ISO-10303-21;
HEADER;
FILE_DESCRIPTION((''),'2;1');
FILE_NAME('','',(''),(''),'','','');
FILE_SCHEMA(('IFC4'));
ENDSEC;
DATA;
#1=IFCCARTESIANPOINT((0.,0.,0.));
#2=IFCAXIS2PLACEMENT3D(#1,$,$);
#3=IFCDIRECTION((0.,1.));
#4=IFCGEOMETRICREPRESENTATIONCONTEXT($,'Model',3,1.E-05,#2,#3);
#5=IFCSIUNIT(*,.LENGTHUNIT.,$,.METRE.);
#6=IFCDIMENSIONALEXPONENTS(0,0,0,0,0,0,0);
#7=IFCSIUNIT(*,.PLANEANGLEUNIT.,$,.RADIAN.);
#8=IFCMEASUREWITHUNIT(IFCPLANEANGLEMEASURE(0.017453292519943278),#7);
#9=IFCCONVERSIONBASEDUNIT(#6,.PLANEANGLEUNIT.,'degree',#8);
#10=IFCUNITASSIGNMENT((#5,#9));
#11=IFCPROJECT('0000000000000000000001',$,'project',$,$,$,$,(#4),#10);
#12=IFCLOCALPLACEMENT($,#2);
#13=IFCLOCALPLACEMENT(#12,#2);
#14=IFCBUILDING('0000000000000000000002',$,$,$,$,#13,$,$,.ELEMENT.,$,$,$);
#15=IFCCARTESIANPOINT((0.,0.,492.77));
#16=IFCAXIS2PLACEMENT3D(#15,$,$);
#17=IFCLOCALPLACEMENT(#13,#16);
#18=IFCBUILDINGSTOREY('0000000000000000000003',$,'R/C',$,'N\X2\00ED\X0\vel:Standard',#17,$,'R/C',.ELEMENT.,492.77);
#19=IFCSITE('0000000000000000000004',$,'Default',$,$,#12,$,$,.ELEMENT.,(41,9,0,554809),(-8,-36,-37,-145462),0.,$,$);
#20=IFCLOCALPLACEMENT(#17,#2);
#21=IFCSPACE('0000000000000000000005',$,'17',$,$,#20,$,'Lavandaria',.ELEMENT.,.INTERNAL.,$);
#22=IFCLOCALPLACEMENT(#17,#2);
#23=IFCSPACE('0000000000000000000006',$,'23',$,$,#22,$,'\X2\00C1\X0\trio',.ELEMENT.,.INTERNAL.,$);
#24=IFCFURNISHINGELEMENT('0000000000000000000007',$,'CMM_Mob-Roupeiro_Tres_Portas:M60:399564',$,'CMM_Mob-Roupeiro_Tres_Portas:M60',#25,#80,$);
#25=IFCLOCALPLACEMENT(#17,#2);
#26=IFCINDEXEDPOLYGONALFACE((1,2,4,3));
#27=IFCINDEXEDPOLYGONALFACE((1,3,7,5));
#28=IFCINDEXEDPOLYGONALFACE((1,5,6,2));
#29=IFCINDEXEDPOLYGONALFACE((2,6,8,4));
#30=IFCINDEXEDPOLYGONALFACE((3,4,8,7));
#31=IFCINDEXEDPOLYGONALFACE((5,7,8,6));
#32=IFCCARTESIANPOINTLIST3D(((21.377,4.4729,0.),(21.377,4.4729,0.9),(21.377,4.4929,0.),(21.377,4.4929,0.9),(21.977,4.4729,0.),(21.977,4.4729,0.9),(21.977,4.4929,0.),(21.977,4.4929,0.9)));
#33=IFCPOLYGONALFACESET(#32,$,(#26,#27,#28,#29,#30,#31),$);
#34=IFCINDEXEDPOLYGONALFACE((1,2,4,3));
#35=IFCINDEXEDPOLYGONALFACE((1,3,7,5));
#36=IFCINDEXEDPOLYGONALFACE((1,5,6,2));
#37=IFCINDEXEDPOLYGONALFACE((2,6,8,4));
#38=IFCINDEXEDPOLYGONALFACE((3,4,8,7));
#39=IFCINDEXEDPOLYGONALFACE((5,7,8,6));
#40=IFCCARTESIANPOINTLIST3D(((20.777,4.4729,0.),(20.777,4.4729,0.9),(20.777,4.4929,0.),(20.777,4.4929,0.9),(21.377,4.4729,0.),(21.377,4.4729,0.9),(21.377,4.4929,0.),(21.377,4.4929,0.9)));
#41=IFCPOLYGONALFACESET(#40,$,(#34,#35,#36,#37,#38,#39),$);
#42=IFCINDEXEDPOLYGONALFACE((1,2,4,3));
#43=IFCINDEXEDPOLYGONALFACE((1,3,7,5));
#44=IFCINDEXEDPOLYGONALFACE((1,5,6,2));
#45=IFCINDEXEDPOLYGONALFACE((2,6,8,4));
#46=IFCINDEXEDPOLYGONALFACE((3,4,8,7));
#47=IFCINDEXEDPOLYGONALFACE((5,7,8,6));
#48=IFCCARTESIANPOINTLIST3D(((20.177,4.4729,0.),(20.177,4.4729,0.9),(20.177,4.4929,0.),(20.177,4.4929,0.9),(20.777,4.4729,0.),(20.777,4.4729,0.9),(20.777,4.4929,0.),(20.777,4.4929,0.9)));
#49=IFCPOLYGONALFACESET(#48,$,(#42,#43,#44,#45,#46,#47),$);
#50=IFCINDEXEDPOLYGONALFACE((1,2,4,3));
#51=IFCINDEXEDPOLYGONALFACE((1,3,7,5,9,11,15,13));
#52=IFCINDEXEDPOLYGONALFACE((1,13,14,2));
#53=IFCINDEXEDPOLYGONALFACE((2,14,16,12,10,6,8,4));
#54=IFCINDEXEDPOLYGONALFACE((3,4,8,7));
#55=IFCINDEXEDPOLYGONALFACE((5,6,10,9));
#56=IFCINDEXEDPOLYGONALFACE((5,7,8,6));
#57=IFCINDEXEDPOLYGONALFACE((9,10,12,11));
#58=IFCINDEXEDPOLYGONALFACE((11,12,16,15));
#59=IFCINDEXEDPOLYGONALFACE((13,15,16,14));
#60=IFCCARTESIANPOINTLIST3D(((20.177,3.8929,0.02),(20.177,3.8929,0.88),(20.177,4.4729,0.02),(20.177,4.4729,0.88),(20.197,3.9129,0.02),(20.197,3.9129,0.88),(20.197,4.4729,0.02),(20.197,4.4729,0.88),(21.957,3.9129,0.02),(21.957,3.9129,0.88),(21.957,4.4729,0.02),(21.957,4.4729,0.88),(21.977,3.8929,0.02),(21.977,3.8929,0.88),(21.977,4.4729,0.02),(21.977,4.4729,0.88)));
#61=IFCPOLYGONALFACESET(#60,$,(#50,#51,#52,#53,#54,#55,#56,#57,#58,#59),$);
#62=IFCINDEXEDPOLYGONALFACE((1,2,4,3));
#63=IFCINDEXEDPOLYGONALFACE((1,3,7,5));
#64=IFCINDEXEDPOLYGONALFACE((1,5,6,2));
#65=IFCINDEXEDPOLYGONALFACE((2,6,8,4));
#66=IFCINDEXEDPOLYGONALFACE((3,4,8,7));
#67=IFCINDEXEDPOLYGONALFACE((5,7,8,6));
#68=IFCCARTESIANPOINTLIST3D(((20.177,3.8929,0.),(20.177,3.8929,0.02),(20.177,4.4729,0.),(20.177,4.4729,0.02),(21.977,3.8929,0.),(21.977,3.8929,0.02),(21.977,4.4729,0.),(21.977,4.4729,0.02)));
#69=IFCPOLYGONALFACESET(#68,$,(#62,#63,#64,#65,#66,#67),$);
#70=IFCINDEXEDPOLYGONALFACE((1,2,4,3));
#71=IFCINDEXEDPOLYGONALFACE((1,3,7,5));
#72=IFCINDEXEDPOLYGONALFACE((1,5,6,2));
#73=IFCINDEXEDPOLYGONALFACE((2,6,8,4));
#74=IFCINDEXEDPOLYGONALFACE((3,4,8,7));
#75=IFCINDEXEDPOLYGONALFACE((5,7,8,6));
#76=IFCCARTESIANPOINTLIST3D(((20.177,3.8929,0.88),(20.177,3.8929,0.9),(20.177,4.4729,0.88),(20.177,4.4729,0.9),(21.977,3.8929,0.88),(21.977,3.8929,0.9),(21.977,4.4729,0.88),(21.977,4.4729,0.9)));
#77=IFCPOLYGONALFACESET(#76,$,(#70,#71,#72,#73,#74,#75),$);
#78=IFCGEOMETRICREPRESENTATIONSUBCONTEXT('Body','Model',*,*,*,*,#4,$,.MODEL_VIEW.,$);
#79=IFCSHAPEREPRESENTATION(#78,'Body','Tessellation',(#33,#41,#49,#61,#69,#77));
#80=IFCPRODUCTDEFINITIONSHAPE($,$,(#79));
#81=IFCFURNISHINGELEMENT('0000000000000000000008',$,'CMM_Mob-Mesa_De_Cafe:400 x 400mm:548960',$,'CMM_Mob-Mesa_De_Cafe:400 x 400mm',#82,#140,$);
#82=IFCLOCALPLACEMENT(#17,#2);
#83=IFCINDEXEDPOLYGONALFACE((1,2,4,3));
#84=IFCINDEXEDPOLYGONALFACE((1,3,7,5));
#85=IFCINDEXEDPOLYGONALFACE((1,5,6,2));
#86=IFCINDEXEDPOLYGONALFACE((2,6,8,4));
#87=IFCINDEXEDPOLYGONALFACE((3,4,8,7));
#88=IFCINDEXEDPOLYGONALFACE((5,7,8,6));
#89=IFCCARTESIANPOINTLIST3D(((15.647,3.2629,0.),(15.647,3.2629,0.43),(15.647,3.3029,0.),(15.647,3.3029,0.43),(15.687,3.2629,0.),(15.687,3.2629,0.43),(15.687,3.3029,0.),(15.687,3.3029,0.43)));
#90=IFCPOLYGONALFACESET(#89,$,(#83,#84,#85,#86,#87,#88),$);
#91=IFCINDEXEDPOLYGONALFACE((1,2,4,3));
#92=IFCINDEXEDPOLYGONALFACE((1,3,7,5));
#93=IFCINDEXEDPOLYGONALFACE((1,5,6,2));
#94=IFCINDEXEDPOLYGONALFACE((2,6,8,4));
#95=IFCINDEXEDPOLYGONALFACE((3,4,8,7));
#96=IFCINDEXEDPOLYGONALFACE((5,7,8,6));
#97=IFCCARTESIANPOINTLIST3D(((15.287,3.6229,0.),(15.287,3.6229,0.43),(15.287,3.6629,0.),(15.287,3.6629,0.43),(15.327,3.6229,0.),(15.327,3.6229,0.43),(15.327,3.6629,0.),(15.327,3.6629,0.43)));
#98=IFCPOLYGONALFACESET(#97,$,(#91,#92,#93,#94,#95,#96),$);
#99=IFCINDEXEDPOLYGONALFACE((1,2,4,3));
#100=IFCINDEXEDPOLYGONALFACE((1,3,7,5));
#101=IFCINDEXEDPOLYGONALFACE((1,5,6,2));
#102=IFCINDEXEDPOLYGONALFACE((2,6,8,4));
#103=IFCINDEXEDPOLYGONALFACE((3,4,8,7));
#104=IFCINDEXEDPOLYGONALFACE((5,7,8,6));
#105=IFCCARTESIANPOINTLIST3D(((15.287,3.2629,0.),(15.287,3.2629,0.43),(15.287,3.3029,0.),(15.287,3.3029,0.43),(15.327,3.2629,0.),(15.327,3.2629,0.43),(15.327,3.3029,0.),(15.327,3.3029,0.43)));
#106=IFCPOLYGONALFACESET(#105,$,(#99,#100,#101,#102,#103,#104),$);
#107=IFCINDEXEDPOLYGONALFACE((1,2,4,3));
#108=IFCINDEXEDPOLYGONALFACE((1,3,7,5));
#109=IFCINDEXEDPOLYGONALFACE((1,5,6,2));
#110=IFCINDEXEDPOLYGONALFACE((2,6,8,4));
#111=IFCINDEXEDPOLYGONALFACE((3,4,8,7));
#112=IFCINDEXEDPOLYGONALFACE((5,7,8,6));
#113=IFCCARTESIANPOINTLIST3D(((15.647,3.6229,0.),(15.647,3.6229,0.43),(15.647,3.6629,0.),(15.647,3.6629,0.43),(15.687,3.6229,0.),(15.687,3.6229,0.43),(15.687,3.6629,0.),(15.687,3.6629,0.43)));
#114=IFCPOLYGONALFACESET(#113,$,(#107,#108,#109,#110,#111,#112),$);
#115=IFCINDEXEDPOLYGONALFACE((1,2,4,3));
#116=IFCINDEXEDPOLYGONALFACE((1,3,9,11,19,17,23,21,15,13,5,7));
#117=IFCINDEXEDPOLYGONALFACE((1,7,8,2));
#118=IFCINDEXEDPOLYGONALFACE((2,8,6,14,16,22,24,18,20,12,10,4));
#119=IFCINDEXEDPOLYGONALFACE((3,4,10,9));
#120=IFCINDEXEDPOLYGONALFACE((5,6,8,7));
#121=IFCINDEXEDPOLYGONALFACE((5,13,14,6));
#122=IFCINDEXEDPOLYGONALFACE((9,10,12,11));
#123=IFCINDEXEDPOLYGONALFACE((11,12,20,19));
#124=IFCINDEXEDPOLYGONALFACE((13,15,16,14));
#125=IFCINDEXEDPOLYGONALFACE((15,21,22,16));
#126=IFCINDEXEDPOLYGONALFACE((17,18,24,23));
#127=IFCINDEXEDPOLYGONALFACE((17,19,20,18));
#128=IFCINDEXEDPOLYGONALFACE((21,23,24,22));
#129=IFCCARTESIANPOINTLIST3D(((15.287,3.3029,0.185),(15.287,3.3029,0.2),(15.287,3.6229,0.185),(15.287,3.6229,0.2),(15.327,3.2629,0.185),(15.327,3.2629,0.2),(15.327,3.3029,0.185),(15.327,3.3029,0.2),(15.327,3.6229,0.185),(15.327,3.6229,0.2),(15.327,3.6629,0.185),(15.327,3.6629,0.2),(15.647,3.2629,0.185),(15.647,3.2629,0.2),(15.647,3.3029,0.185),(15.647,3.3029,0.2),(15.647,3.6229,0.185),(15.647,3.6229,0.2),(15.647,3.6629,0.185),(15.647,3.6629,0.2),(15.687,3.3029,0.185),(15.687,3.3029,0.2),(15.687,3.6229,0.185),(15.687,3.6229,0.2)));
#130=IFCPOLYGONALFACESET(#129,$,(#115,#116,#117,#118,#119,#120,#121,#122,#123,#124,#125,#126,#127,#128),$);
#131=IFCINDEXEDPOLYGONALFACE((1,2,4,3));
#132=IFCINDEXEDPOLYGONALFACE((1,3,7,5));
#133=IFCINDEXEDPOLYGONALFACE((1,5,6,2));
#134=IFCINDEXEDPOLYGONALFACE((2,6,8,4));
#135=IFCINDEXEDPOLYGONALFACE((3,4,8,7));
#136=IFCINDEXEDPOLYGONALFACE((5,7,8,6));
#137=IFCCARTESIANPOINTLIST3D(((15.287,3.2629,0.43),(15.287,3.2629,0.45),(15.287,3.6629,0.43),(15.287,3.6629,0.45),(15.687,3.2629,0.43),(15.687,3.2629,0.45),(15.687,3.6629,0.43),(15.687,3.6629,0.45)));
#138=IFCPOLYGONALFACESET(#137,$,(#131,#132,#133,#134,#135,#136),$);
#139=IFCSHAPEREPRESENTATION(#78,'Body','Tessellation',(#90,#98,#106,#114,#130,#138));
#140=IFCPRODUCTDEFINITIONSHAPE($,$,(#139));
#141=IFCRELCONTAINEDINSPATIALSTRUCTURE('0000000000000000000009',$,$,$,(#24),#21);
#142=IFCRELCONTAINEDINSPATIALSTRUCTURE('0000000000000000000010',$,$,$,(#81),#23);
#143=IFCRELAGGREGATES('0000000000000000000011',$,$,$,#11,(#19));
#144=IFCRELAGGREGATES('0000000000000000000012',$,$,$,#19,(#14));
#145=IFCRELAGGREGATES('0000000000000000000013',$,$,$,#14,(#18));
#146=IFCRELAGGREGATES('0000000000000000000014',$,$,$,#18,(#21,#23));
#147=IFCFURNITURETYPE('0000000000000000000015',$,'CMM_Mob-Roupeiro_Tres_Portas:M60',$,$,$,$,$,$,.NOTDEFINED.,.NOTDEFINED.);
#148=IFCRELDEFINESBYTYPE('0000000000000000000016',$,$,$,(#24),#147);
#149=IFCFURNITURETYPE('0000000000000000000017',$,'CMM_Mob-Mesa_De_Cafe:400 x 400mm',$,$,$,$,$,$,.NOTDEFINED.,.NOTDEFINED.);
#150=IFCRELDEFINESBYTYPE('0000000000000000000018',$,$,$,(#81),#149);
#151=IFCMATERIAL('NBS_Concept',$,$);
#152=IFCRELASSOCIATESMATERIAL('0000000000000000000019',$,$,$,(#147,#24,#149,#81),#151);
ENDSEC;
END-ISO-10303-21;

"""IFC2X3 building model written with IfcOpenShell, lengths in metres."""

from ifc_helpers import new_model, entity, si_unit, converted_unit, direction, frame, frame_2d, origin, origin_2d_with_axis, place, context, subcontext, project, spatial, polyline, rectangle, outline, extrude, source, transform, mapped, material, type_object, type_shapes, element, save


model = new_model("IFC2X3")

# Units and contexts
model_context = context("Model", 3, precision=1e-05, world=origin(), true_north=direction((0.0, 1.0)))
body_context = subcontext(model_context, "Body", "Model", "MODEL_VIEW")
ifc_project = project(units=[si_unit("LENGTHUNIT", "METRE"), converted_unit("PLANEANGLEUNIT", "degree", entity("IfcPlaneAngleMeasure", 0.017453292519943278), si_unit("PLANEANGLEUNIT", "RADIAN"), dimensions=[0, 0, 0, 0, 0, 0, 0])], contexts=[model_context])

# Site, building, storey
site_placement = place(None, origin())
site = spatial("IfcSite", under=ifc_project, at=site_placement, Name="Default", CompositionType="ELEMENT", RefLatitude=(41, 9, 0, 554809), RefLongitude=(-8, -36, -37, -145462), RefElevation=0.0)
building_placement = place(site_placement, origin())
building = spatial("IfcBuilding", under=site, at=building_placement, CompositionType="ELEMENT")
storey_placement = place(building_placement, frame((0.0, 0.0, 492.77)))
storey = spatial("IfcBuildingStorey", under=building, at=storey_placement, Name="R/C", ObjectType="Nível:Standard", LongName="R/C", CompositionType="ELEMENT", Elevation=492.77)

# Shared definitions
ifc_material_1 = material(Name="NBS_Concept")

# Shared definitions
space_1_placement = place(storey_placement, origin())
space_1 = spatial("IfcSpace", under=storey, at=space_1_placement, Name="17", LongName="Lavandaria", CompositionType="ELEMENT", InteriorOrExteriorSpace="INTERNAL")

# Furnishing element
furniture_type_1 = type_object("IfcFurnitureType", Name="CMM_Mob-Roupeiro_Tres_Portas:M60", AssemblyPlace="NOTDEFINED", material=ifc_material_1)
shared_shape_1 = source(origin(), body_context, "Body", "SweptSolid", [
    extrude(rectangle(XDim=0.6, YDim=0.02, at=frame_2d((0.0, 0.0), x_axis=(1.0, 0.0))), frame((1.5, 0.59, 0.0), z_axis=(0.0, 0.0, 1.0), x_axis=(-1.0, 0.0, 0.0)), (0.0, 0.0, 1.0), 0.9),
    extrude(rectangle(XDim=0.6, YDim=0.02, at=frame_2d((0.0, 0.0), x_axis=(1.0, 0.0))), frame((0.9, 0.59, 0.0), z_axis=(0.0, 0.0, 1.0), x_axis=(-1.0, 0.0, 0.0)), (0.0, 0.0, 1.0), 0.9),
    extrude(rectangle(XDim=0.6, YDim=0.02, at=frame_2d((0.0, 0.0), x_axis=(1.0, 0.0))), frame((0.3, 0.59, 0.0), z_axis=(0.0, 0.0, 1.0), x_axis=(-1.0, 0.0, 0.0)), (0.0, 0.0, 1.0), 0.9),
    extrude(outline(polyline([(-0.9, -0.295), (0.9, -0.295), (0.9, 0.285), (0.88, 0.285), (0.88, -0.275), (-0.88, -0.275), (-0.88, 0.285), (-0.9, 0.285), (-0.9, -0.295)])), frame((0.9, 0.295, 0.02)), (0.0, 0.0, 1.0), 0.86),
    extrude(rectangle(XDim=1.8, YDim=0.58, at=frame_2d((0.0, 0.0), x_axis=(1.0, 0.0))), frame((0.9, 0.29, 0.0), z_axis=(0.0, 0.0, 1.0), x_axis=(-1.0, 0.0, 0.0)), (0.0, 0.0, 1.0), 0.02),
    extrude(rectangle(XDim=1.8, YDim=0.58, at=frame_2d((0.0, 0.0), x_axis=(1.0, 0.0))), frame((0.9, 0.29, 0.88), z_axis=(0.0, 0.0, 1.0), x_axis=(-1.0, 0.0, 0.0)), (0.0, 0.0, 1.0), 0.02),
])
type_shapes(furniture_type_1, [shared_shape_1])
furnishing_1_placement = place(space_1_placement, frame((20.177, 3.8929, 0.0)))
element("IfcFurnishingElement", 1, at=furnishing_1_placement, inside=space_1, type_object=furniture_type_1, material=ifc_material_1, Name="CMM_Mob-Roupeiro_Tres_Portas:M60:399564", ObjectType="CMM_Mob-Roupeiro_Tres_Portas:M60", context=body_context, shape_type="MappedRepresentation", body=[
    mapped(shared_shape_1, transform((0.0, 0.0, 0.0), scale=1.0)),
])

# Shared definitions
space_2_placement = place(storey_placement, origin())
space_2 = spatial("IfcSpace", under=storey, at=space_2_placement, Name="23", LongName="Átrio", CompositionType="ELEMENT", InteriorOrExteriorSpace="INTERNAL")

# Furnishing element
furniture_type_2 = type_object("IfcFurnitureType", Name="CMM_Mob-Mesa_De_Cafe:400 x 400mm", AssemblyPlace="NOTDEFINED", material=ifc_material_1)
shared_shape_2 = source(origin(), body_context, "Body", "SweptSolid", [
    extrude(rectangle(XDim=0.04, YDim=0.04, at=origin_2d_with_axis()), frame((0.18, -0.18, 0.0), z_axis=(0.0, 0.0, 1.0), x_axis=(-1.0, 0.0, 0.0)), (0.0, 0.0, 1.0), 0.43),
    extrude(rectangle(XDim=0.04, YDim=0.04, at=origin_2d_with_axis()), frame((-0.18, 0.18, 0.0), z_axis=(0.0, 0.0, 1.0), x_axis=(-1.0, 0.0, 0.0)), (0.0, 0.0, 1.0), 0.43),
    extrude(rectangle(XDim=0.04, YDim=0.04, at=origin_2d_with_axis()), frame((-0.18, -0.18, 0.0), z_axis=(0.0, 0.0, 1.0), x_axis=(-1.0, 0.0, 0.0)), (0.0, 0.0, 1.0), 0.43),
    extrude(rectangle(XDim=0.04, YDim=0.04, at=frame_2d((0.0, 0.0), x_axis=(1.0, 0.0))), frame((0.18, 0.18, 0.0)), (0.0, 0.0, 1.0), 0.43),
    extrude(outline(polyline([(-0.2, 0.16), (-0.2, -0.16), (-0.16, -0.16), (-0.16, -0.2), (0.16, -0.2), (0.16, -0.16), (0.2, -0.16), (0.2, 0.16), (0.16, 0.16), (0.16, 0.2), (-0.16, 0.2), (-0.16, 0.16), (-0.2, 0.16)])), frame((0.0, 0.0, 0.185), z_axis=(0.0, 0.0, -1.0), x_axis=(1.0, 0.0, 0.0)), (0.0, 0.0, -1.0), 0.015),
    extrude(rectangle(XDim=0.4, YDim=0.4, at=origin_2d_with_axis()), frame((0.0, 0.0, 0.43)), (0.0, 0.0, 1.0), 0.02),
])
type_shapes(furniture_type_2, [shared_shape_2])
furnishing_2_placement = place(space_2_placement, frame((15.487, 3.4629, 0.0)))
element("IfcFurnishingElement", 2, at=furnishing_2_placement, inside=space_2, type_object=furniture_type_2, material=ifc_material_1, Name="CMM_Mob-Mesa_De_Cafe:400 x 400mm:548960", ObjectType="CMM_Mob-Mesa_De_Cafe:400 x 400mm", context=body_context, shape_type="MappedRepresentation", body=[
    mapped(shared_shape_2, transform((0.0, 0.0, 0.0), scale=1.0)),
])

save(model, "model.ifc")
